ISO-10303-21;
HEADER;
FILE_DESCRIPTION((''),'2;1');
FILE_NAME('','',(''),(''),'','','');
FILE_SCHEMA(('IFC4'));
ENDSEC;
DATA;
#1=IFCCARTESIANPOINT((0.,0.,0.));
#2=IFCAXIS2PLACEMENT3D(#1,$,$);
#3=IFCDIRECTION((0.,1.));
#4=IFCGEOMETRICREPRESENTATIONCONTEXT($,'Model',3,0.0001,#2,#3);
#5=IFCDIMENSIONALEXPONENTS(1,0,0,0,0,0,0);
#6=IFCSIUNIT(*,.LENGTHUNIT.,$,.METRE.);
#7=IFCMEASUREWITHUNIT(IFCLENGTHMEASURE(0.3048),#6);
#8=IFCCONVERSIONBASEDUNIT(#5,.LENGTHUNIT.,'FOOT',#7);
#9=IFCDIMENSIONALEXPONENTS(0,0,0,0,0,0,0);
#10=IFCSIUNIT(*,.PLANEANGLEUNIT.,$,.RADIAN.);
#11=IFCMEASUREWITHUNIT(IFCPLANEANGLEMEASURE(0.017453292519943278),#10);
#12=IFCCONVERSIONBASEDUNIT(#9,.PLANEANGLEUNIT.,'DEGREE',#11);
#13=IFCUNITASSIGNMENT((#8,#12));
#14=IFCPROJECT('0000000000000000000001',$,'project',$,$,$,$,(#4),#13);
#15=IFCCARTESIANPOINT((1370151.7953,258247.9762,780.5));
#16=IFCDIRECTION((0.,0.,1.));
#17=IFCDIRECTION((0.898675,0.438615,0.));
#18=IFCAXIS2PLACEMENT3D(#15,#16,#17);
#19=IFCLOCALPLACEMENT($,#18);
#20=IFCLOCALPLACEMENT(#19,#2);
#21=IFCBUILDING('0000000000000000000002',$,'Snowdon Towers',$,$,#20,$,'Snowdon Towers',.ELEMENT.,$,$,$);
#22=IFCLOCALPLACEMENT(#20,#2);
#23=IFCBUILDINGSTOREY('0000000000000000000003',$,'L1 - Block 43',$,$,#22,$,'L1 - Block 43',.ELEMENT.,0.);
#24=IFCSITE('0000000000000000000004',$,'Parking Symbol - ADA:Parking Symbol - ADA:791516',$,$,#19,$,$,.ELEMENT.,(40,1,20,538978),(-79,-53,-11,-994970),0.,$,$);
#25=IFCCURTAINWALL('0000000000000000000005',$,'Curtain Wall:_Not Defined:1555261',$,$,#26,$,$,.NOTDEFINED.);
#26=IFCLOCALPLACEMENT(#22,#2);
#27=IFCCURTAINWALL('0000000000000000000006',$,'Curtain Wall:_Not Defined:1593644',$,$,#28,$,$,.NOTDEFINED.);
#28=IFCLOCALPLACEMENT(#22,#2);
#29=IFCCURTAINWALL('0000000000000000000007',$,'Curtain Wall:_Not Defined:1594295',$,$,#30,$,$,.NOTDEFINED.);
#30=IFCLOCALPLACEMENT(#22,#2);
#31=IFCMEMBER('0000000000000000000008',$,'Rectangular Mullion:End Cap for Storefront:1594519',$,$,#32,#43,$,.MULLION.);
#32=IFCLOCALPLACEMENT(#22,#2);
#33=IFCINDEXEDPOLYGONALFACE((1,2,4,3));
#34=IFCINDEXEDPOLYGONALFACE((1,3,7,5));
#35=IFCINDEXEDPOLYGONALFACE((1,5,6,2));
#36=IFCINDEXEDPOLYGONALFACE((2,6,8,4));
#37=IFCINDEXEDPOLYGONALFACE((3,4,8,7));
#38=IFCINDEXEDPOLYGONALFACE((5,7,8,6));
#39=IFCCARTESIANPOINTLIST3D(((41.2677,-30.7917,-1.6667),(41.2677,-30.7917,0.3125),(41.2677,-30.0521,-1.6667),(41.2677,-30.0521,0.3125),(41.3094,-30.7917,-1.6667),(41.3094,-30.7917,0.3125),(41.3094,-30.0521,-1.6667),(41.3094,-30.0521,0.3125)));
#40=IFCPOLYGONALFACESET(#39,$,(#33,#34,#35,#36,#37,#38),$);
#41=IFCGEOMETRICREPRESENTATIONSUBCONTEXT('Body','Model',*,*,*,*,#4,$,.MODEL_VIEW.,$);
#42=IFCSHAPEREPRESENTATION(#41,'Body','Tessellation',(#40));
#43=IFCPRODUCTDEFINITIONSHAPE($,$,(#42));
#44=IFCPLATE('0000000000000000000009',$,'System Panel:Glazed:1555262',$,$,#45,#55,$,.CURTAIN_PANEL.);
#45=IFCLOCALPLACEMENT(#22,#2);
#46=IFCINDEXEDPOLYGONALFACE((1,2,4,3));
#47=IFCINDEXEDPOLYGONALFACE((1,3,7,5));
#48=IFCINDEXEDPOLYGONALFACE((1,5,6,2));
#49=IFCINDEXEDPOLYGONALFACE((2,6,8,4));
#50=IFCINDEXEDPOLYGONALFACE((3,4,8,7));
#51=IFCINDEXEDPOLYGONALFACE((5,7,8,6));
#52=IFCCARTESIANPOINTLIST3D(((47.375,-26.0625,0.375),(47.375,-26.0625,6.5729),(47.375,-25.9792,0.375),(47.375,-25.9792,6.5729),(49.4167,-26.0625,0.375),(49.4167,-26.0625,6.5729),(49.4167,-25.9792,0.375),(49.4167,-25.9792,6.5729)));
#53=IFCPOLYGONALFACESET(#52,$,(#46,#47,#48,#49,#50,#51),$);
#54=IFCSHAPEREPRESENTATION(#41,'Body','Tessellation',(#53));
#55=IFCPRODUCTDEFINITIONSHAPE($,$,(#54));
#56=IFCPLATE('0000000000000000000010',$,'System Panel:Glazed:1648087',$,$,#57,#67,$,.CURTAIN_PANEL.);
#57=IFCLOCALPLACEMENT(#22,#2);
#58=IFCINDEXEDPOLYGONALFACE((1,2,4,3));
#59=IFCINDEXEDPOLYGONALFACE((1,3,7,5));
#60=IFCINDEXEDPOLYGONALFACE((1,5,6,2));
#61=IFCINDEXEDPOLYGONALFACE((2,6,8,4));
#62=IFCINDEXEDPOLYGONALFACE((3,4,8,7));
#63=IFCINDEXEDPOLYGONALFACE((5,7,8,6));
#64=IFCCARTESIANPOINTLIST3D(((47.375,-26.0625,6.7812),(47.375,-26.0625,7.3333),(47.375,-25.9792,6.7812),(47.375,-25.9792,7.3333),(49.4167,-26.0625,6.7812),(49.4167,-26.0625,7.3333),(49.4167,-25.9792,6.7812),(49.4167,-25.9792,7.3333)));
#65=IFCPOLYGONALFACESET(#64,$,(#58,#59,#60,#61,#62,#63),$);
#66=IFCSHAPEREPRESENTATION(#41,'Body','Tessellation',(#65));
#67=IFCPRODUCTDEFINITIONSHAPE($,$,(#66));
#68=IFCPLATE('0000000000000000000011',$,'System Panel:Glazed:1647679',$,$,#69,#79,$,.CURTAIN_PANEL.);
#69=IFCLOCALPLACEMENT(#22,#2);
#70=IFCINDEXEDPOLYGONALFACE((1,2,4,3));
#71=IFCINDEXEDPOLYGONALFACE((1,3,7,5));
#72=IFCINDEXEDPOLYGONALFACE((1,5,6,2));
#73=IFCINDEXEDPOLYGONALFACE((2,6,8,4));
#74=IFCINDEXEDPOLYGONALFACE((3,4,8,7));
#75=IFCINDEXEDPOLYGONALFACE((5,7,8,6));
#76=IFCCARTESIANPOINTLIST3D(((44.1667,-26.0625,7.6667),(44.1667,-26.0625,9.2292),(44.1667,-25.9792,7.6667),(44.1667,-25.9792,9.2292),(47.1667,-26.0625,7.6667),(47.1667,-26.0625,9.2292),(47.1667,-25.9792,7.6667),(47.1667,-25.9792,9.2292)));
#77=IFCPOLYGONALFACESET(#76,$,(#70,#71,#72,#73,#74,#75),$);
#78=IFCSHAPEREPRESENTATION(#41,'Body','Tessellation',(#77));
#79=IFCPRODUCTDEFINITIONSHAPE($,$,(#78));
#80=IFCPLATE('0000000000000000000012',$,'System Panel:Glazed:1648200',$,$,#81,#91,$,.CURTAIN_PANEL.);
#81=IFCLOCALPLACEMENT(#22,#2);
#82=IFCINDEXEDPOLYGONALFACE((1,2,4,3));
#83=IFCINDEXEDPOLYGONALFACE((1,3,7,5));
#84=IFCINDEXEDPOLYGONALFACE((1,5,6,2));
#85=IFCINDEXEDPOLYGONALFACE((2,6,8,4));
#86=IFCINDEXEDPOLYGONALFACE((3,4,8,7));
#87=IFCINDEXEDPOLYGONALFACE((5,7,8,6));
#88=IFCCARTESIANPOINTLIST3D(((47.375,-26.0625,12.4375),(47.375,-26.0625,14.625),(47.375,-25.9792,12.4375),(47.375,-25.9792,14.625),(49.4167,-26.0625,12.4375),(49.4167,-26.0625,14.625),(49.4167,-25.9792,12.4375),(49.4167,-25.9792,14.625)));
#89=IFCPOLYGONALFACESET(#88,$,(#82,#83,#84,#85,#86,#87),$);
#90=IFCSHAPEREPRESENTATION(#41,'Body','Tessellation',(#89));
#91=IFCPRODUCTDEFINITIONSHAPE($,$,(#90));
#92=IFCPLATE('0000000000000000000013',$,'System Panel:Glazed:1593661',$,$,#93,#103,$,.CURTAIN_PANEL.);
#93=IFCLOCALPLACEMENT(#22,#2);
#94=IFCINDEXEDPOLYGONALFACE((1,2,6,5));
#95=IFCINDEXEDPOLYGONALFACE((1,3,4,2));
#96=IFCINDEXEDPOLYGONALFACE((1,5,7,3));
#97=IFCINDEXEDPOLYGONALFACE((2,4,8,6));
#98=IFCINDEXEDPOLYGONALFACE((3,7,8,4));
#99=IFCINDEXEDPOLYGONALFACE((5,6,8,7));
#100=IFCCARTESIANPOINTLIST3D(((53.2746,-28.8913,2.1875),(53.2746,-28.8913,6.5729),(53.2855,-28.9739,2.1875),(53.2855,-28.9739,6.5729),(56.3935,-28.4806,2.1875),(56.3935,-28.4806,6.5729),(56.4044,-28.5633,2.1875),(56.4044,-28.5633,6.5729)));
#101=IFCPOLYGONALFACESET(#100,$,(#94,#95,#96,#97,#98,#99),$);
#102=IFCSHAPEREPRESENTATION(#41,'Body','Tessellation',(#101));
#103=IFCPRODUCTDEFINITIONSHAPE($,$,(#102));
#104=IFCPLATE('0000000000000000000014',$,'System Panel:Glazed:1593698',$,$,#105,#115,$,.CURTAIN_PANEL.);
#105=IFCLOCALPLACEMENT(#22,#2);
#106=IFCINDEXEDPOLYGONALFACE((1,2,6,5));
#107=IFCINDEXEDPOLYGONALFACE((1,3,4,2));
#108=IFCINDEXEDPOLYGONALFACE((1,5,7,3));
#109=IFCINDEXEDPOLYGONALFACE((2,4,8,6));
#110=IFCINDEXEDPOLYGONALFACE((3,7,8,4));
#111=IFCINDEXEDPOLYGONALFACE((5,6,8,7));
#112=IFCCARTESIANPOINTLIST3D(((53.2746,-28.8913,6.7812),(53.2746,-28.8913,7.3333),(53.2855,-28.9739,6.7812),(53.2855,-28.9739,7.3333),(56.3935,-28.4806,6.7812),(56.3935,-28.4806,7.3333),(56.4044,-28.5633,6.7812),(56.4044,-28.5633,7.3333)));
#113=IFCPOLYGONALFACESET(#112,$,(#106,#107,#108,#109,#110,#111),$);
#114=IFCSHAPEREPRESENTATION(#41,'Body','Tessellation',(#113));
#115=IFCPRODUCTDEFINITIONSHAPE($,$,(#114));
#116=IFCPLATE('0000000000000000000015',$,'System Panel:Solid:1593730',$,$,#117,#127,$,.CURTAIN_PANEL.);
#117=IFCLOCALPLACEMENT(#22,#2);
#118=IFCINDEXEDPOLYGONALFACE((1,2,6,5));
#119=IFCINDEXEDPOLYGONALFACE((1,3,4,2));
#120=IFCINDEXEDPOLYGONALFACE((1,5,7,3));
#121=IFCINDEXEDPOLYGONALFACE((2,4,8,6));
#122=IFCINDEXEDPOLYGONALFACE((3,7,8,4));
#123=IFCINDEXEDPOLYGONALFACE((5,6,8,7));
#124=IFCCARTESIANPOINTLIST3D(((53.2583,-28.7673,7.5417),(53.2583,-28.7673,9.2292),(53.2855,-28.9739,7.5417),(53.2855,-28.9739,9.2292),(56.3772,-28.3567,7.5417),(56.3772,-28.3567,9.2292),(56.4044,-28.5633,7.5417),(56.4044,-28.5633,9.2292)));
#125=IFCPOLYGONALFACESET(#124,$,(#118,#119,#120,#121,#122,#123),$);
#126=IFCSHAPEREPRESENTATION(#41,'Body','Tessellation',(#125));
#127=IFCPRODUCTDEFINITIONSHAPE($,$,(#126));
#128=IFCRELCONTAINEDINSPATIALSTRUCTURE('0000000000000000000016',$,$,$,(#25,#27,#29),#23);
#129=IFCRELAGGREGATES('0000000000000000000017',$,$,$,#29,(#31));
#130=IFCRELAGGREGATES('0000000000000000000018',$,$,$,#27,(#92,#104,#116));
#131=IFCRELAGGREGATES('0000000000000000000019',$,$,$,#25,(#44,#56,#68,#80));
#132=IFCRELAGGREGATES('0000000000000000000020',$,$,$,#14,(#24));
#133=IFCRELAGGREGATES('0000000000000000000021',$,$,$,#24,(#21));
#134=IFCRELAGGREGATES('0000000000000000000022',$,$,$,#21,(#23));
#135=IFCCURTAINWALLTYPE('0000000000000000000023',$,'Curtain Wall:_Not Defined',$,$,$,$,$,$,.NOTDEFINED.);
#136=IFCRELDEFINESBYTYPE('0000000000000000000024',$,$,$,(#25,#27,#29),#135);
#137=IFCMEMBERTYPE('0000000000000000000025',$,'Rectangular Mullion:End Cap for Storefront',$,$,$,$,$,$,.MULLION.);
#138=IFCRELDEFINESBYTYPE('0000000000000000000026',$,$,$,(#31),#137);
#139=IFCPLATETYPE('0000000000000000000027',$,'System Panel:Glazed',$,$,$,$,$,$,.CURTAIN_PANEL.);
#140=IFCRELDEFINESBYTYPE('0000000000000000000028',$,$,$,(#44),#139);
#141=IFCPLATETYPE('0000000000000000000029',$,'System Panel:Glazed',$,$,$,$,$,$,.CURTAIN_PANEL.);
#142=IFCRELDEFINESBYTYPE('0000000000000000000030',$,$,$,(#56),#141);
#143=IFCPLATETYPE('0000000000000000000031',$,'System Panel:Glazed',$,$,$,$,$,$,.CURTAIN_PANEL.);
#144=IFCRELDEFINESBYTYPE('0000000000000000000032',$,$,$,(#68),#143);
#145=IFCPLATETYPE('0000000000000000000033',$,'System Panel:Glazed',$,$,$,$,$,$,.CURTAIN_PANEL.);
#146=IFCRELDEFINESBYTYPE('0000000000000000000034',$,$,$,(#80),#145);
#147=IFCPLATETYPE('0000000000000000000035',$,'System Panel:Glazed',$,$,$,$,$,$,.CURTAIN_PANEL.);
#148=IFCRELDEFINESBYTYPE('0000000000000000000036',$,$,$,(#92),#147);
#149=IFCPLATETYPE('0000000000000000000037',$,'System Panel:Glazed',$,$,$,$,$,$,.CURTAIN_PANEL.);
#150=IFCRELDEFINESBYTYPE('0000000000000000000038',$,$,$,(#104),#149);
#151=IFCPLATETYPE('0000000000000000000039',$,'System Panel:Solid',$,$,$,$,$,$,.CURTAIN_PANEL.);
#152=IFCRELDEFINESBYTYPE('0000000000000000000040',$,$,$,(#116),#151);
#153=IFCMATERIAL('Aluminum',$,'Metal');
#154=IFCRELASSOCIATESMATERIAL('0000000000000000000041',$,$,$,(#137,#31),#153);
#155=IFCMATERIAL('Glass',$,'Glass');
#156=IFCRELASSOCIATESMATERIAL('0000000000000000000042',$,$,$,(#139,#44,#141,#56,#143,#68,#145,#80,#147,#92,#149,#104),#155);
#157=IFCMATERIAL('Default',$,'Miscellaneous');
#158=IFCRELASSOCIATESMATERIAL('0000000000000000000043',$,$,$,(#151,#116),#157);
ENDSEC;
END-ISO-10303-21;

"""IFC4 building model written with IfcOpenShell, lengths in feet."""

from ifc_helpers import new_model, entity, si_unit, converted_unit, direction, frame, origin, place, context, subcontext, project, spatial, indexed_curve, outline, extrude, source, transform, mapped, material, type_object, type_shapes, element, aggregate, save


model = new_model("IFC4")

# Units and contexts
model_context = context("Model", 3, precision=0.0001, world=origin(), true_north=direction((0.0, 1.0)))
body_context = subcontext(model_context, "Body", "Model", "MODEL_VIEW")
ifc_project = project(units=[converted_unit("LENGTHUNIT", "FOOT", entity("IfcLengthMeasure", 0.3048), si_unit("LENGTHUNIT", "METRE"), dimensions=[1, 0, 0, 0, 0, 0, 0]), converted_unit("PLANEANGLEUNIT", "DEGREE", entity("IfcPlaneAngleMeasure", 0.017453292519943278), si_unit("PLANEANGLEUNIT", "RADIAN"), dimensions=[0, 0, 0, 0, 0, 0, 0])], contexts=[model_context])

# Site, building, storey
site_placement = place(None, frame((1370151.7953, 258247.9762, 780.5), z_axis=(0.0, 0.0, 1.0), x_axis=(0.898675, 0.438615, 0.0)))
site = spatial("IfcSite", under=ifc_project, at=site_placement, Name="Parking Symbol - ADA:Parking Symbol - ADA:791516", CompositionType="ELEMENT", RefLatitude=(40, 1, 20, 538978), RefLongitude=(-79, -53, -11, -994970), RefElevation=0.0)
building_placement = place(site_placement, origin())
building = spatial("IfcBuilding", under=site, at=building_placement, Name="Snowdon Towers", LongName="Snowdon Towers", CompositionType="ELEMENT")
storey_placement = place(building_placement, origin())
storey = spatial("IfcBuildingStorey", under=building, at=storey_placement, Name="L1 - Block 43", LongName="L1 - Block 43", CompositionType="ELEMENT", Elevation=0.0)

# Curtain walls
curtain_wall_type = type_object("IfcCurtainWallType", Name="Curtain Wall:_Not Defined", PredefinedType="NOTDEFINED")
curtain_wall_1_placement = place(storey_placement, origin())
curtain_wall_1 = element("IfcCurtainWall", 1, at=curtain_wall_1_placement, inside=storey, type_object=curtain_wall_type, Name="Curtain Wall:_Not Defined:1555261", PredefinedType="NOTDEFINED")
ifc_material_1 = material(Name="Aluminum", Category="Metal")
curtain_wall_2_placement = place(storey_placement, origin())
curtain_wall_2 = element("IfcCurtainWall", 2, at=curtain_wall_2_placement, inside=storey, type_object=curtain_wall_type, Name="Curtain Wall:_Not Defined:1593644", PredefinedType="NOTDEFINED")

# Curtain wall, member
curtain_wall_3_placement = place(storey_placement, origin())
curtain_wall_3 = element("IfcCurtainWall", 3, at=curtain_wall_3_placement, inside=storey, type_object=curtain_wall_type, Name="Curtain Wall:_Not Defined:1594295", PredefinedType="NOTDEFINED")
member_type_1 = type_object("IfcMemberType", Name="Rectangular Mullion:End Cap for Storefront", PredefinedType="MULLION", material=ifc_material_1)
shared_shape_1 = source(origin(), body_context, "Body", "SweptSolid", [
    extrude(outline(indexed_curve([(-0.0208, -0.3698), (0.0208, -0.3698), (0.0208, 0.3698), (-0.0208, 0.3698), (-0.0208, -0.3698)], self_intersect=False)), frame((-0.0208, 0.0, -1.9792), z_axis=(0.0, 0.0, 1.0), x_axis=(-1.0, 0.0, 0.0)), (0.0, 0.0, 1.0), 1.9792),
])
type_shapes(member_type_1, [shared_shape_1])
member_1_placement = place(curtain_wall_3_placement, frame((41.3094, -30.4219, -1.6667), z_axis=(0.0, 0.0, -1.0), x_axis=(1.0, 0.0, 0.0)))
member_1 = element("IfcMember", 4, at=member_1_placement, type_object=member_type_1, material=ifc_material_1, Name="Rectangular Mullion:End Cap for Storefront:1594519", PredefinedType="MULLION", context=body_context, shape_type="MappedRepresentation", body=[
    mapped(shared_shape_1, transform((0.0, 0.0, 0.0), scale=1.0)),
])
aggregate(curtain_wall_3, [member_1])

# Plates
ifc_material_2 = material(Name="Glass", Category="Glass")
plate_type_1 = type_object("IfcPlateType", Name="System Panel:Glazed", PredefinedType="CURTAIN_PANEL", material=ifc_material_2)
shared_shape_2 = source(origin(), body_context, "Body", "SweptSolid", [
    extrude(outline(indexed_curve([(-0.0417, -1.0208), (0.0417, -1.0208), (0.0417, 1.0208), (-0.0417, 1.0208), (-0.0417, -1.0208)], self_intersect=False)), frame((0.0, 0.1042, 0.0), z_axis=(0.0, 0.0, 1.0), x_axis=(0.0, 1.0, 0.0)), (0.0, 0.0, 1.0), 6.1979),
])
type_shapes(plate_type_1, [shared_shape_2])
plate_1_placement = place(curtain_wall_1_placement, frame((48.3958, -25.9167, 0.375), z_axis=(0.0, 0.0, 1.0), x_axis=(-1.0, 0.0, 0.0)))
plate_1 = element("IfcPlate", 5, at=plate_1_placement, type_object=plate_type_1, material=ifc_material_2, Name="System Panel:Glazed:1555262", PredefinedType="CURTAIN_PANEL", context=body_context, shape_type="MappedRepresentation", body=[
    mapped(shared_shape_2, transform((0.0, 0.0, 0.0), scale=1.0)),
])
plate_type_2 = type_object("IfcPlateType", Name="System Panel:Glazed", PredefinedType="CURTAIN_PANEL", material=ifc_material_2)
shared_shape_3 = source(origin(), body_context, "Body", "SweptSolid", [
    extrude(outline(indexed_curve([(-0.0417, -1.0208), (0.0417, -1.0208), (0.0417, 1.0208), (-0.0417, 1.0208), (-0.0417, -1.0208)], self_intersect=False)), frame((0.0, 0.1042, 0.0), z_axis=(0.0, 0.0, 1.0), x_axis=(0.0, 1.0, 0.0)), (0.0, 0.0, 1.0), 0.5521),
])
type_shapes(plate_type_2, [shared_shape_3])
plate_2_placement = place(curtain_wall_1_placement, frame((48.3958, -25.9167, 6.7812), z_axis=(0.0, 0.0, 1.0), x_axis=(-1.0, 0.0, 0.0)))
plate_2 = element("IfcPlate", 6, at=plate_2_placement, type_object=plate_type_2, material=ifc_material_2, Name="System Panel:Glazed:1648087", PredefinedType="CURTAIN_PANEL", context=body_context, shape_type="MappedRepresentation", body=[
    mapped(shared_shape_3, transform((0.0, 0.0, 0.0), scale=1.0)),
])
plate_type_3 = type_object("IfcPlateType", Name="System Panel:Glazed", PredefinedType="CURTAIN_PANEL", material=ifc_material_2)
shared_shape_4 = source(origin(), body_context, "Body", "SweptSolid", [
    extrude(outline(indexed_curve([(-0.0417, -1.5), (0.0417, -1.5), (0.0417, 1.5), (-0.0417, 1.5), (-0.0417, -1.5)], self_intersect=False)), frame((0.0, 0.1042, 0.0), z_axis=(0.0, 0.0, 1.0), x_axis=(0.0, 1.0, 0.0)), (0.0, 0.0, 1.0), 1.5625),
])
type_shapes(plate_type_3, [shared_shape_4])
plate_3_placement = place(curtain_wall_1_placement, frame((45.6667, -25.9167, 7.6667), z_axis=(0.0, 0.0, 1.0), x_axis=(-1.0, 0.0, 0.0)))
plate_3 = element("IfcPlate", 7, at=plate_3_placement, type_object=plate_type_3, material=ifc_material_2, Name="System Panel:Glazed:1647679", PredefinedType="CURTAIN_PANEL", context=body_context, shape_type="MappedRepresentation", body=[
    mapped(shared_shape_4, transform((0.0, 0.0, 0.0), scale=1.0)),
])
plate_type_4 = type_object("IfcPlateType", Name="System Panel:Glazed", PredefinedType="CURTAIN_PANEL", material=ifc_material_2)
shared_shape_5 = source(origin(), body_context, "Body", "SweptSolid", [
    extrude(outline(indexed_curve([(-0.0417, -1.0208), (0.0417, -1.0208), (0.0417, 1.0208), (-0.0417, 1.0208), (-0.0417, -1.0208)], self_intersect=False)), frame((0.0, 0.1042, 0.0), z_axis=(0.0, 0.0, 1.0), x_axis=(0.0, 1.0, 0.0)), (0.0, 0.0, 1.0), 2.1875),
])
type_shapes(plate_type_4, [shared_shape_5])
plate_4_placement = place(curtain_wall_1_placement, frame((48.3958, -25.9167, 12.4375), z_axis=(0.0, 0.0, 1.0), x_axis=(-1.0, 0.0, 0.0)))
plate_4 = element("IfcPlate", 8, at=plate_4_placement, type_object=plate_type_4, material=ifc_material_2, Name="System Panel:Glazed:1648200", PredefinedType="CURTAIN_PANEL", context=body_context, shape_type="MappedRepresentation", body=[
    mapped(shared_shape_5, transform((0.0, 0.0, 0.0), scale=1.0)),
])
plate_type_5 = type_object("IfcPlateType", Name="System Panel:Glazed", PredefinedType="CURTAIN_PANEL", material=ifc_material_2)
shared_shape_6 = source(origin(), body_context, "Body", "SweptSolid", [
    extrude(outline(indexed_curve([(-0.0417, -1.5729), (0.0417, -1.5729), (0.0417, 1.5729), (-0.0417, 1.5729), (-0.0417, -1.5729)], self_intersect=False)), frame((0.0, -0.1042, 0.0), z_axis=(0.0, 0.0, 1.0), x_axis=(0.0, 1.0, 0.0)), (0.0, 0.0, 1.0), 4.3854),
])
type_shapes(plate_type_5, [shared_shape_6])
plate_5_placement = place(curtain_wall_2_placement, frame((54.8259, -28.624, 2.1875), z_axis=(0.0, 0.0, 1.0), x_axis=(0.991445, 0.130526, 0.0)))
plate_5 = element("IfcPlate", 9, at=plate_5_placement, type_object=plate_type_5, material=ifc_material_2, Name="System Panel:Glazed:1593661", PredefinedType="CURTAIN_PANEL", context=body_context, shape_type="MappedRepresentation", body=[
    mapped(shared_shape_6, transform((0.0, 0.0, 0.0), scale=1.0)),
])
plate_type_6 = type_object("IfcPlateType", Name="System Panel:Glazed", PredefinedType="CURTAIN_PANEL", material=ifc_material_2)
shared_shape_7 = source(origin(), body_context, "Body", "SweptSolid", [
    extrude(outline(indexed_curve([(-0.0417, -1.5729), (0.0417, -1.5729), (0.0417, 1.5729), (-0.0417, 1.5729), (-0.0417, -1.5729)], self_intersect=False)), frame((0.0, -0.1042, 0.0), z_axis=(0.0, 0.0, 1.0), x_axis=(0.0, 1.0, 0.0)), (0.0, 0.0, 1.0), 0.5521),
])
type_shapes(plate_type_6, [shared_shape_7])
plate_6_placement = place(curtain_wall_2_placement, frame((54.8259, -28.624, 6.7812), z_axis=(0.0, 0.0, 1.0), x_axis=(0.991445, 0.130526, 0.0)))
plate_6 = element("IfcPlate", 10, at=plate_6_placement, type_object=plate_type_6, material=ifc_material_2, Name="System Panel:Glazed:1593698", PredefinedType="CURTAIN_PANEL", context=body_context, shape_type="MappedRepresentation", body=[
    mapped(shared_shape_7, transform((0.0, 0.0, 0.0), scale=1.0)),
])
ifc_material_3 = material(Name="Default", Category="Miscellaneous")
plate_type_7 = type_object("IfcPlateType", Name="System Panel:Solid", PredefinedType="CURTAIN_PANEL", material=ifc_material_3)
shared_shape_8 = source(origin(), body_context, "Body", "SweptSolid", [
    extrude(outline(indexed_curve([(-0.1042, -1.5729), (0.1042, -1.5729), (0.1042, 1.5729), (-0.1042, 1.5729), (-0.1042, -1.5729)], self_intersect=False)), frame((0.0, -0.0417, 0.0), z_axis=(0.0, 0.0, 1.0), x_axis=(0.0, 1.0, 0.0)), (0.0, 0.0, 1.0), 1.6875),
])
type_shapes(plate_type_7, [shared_shape_8])
plate_7_placement = place(curtain_wall_2_placement, frame((54.8259, -28.624, 7.5417), z_axis=(0.0, 0.0, 1.0), x_axis=(0.991445, 0.130526, 0.0)))
plate_7 = element("IfcPlate", 11, at=plate_7_placement, type_object=plate_type_7, material=ifc_material_3, Name="System Panel:Solid:1593730", PredefinedType="CURTAIN_PANEL", context=body_context, shape_type="MappedRepresentation", body=[
    mapped(shared_shape_8, transform((0.0, 0.0, 0.0), scale=1.0)),
])
aggregate(curtain_wall_2, [plate_5, plate_6, plate_7])

aggregate(curtain_wall_1, [plate_1, plate_2, plate_3, plate_4])

save(model, "model.ifc")
